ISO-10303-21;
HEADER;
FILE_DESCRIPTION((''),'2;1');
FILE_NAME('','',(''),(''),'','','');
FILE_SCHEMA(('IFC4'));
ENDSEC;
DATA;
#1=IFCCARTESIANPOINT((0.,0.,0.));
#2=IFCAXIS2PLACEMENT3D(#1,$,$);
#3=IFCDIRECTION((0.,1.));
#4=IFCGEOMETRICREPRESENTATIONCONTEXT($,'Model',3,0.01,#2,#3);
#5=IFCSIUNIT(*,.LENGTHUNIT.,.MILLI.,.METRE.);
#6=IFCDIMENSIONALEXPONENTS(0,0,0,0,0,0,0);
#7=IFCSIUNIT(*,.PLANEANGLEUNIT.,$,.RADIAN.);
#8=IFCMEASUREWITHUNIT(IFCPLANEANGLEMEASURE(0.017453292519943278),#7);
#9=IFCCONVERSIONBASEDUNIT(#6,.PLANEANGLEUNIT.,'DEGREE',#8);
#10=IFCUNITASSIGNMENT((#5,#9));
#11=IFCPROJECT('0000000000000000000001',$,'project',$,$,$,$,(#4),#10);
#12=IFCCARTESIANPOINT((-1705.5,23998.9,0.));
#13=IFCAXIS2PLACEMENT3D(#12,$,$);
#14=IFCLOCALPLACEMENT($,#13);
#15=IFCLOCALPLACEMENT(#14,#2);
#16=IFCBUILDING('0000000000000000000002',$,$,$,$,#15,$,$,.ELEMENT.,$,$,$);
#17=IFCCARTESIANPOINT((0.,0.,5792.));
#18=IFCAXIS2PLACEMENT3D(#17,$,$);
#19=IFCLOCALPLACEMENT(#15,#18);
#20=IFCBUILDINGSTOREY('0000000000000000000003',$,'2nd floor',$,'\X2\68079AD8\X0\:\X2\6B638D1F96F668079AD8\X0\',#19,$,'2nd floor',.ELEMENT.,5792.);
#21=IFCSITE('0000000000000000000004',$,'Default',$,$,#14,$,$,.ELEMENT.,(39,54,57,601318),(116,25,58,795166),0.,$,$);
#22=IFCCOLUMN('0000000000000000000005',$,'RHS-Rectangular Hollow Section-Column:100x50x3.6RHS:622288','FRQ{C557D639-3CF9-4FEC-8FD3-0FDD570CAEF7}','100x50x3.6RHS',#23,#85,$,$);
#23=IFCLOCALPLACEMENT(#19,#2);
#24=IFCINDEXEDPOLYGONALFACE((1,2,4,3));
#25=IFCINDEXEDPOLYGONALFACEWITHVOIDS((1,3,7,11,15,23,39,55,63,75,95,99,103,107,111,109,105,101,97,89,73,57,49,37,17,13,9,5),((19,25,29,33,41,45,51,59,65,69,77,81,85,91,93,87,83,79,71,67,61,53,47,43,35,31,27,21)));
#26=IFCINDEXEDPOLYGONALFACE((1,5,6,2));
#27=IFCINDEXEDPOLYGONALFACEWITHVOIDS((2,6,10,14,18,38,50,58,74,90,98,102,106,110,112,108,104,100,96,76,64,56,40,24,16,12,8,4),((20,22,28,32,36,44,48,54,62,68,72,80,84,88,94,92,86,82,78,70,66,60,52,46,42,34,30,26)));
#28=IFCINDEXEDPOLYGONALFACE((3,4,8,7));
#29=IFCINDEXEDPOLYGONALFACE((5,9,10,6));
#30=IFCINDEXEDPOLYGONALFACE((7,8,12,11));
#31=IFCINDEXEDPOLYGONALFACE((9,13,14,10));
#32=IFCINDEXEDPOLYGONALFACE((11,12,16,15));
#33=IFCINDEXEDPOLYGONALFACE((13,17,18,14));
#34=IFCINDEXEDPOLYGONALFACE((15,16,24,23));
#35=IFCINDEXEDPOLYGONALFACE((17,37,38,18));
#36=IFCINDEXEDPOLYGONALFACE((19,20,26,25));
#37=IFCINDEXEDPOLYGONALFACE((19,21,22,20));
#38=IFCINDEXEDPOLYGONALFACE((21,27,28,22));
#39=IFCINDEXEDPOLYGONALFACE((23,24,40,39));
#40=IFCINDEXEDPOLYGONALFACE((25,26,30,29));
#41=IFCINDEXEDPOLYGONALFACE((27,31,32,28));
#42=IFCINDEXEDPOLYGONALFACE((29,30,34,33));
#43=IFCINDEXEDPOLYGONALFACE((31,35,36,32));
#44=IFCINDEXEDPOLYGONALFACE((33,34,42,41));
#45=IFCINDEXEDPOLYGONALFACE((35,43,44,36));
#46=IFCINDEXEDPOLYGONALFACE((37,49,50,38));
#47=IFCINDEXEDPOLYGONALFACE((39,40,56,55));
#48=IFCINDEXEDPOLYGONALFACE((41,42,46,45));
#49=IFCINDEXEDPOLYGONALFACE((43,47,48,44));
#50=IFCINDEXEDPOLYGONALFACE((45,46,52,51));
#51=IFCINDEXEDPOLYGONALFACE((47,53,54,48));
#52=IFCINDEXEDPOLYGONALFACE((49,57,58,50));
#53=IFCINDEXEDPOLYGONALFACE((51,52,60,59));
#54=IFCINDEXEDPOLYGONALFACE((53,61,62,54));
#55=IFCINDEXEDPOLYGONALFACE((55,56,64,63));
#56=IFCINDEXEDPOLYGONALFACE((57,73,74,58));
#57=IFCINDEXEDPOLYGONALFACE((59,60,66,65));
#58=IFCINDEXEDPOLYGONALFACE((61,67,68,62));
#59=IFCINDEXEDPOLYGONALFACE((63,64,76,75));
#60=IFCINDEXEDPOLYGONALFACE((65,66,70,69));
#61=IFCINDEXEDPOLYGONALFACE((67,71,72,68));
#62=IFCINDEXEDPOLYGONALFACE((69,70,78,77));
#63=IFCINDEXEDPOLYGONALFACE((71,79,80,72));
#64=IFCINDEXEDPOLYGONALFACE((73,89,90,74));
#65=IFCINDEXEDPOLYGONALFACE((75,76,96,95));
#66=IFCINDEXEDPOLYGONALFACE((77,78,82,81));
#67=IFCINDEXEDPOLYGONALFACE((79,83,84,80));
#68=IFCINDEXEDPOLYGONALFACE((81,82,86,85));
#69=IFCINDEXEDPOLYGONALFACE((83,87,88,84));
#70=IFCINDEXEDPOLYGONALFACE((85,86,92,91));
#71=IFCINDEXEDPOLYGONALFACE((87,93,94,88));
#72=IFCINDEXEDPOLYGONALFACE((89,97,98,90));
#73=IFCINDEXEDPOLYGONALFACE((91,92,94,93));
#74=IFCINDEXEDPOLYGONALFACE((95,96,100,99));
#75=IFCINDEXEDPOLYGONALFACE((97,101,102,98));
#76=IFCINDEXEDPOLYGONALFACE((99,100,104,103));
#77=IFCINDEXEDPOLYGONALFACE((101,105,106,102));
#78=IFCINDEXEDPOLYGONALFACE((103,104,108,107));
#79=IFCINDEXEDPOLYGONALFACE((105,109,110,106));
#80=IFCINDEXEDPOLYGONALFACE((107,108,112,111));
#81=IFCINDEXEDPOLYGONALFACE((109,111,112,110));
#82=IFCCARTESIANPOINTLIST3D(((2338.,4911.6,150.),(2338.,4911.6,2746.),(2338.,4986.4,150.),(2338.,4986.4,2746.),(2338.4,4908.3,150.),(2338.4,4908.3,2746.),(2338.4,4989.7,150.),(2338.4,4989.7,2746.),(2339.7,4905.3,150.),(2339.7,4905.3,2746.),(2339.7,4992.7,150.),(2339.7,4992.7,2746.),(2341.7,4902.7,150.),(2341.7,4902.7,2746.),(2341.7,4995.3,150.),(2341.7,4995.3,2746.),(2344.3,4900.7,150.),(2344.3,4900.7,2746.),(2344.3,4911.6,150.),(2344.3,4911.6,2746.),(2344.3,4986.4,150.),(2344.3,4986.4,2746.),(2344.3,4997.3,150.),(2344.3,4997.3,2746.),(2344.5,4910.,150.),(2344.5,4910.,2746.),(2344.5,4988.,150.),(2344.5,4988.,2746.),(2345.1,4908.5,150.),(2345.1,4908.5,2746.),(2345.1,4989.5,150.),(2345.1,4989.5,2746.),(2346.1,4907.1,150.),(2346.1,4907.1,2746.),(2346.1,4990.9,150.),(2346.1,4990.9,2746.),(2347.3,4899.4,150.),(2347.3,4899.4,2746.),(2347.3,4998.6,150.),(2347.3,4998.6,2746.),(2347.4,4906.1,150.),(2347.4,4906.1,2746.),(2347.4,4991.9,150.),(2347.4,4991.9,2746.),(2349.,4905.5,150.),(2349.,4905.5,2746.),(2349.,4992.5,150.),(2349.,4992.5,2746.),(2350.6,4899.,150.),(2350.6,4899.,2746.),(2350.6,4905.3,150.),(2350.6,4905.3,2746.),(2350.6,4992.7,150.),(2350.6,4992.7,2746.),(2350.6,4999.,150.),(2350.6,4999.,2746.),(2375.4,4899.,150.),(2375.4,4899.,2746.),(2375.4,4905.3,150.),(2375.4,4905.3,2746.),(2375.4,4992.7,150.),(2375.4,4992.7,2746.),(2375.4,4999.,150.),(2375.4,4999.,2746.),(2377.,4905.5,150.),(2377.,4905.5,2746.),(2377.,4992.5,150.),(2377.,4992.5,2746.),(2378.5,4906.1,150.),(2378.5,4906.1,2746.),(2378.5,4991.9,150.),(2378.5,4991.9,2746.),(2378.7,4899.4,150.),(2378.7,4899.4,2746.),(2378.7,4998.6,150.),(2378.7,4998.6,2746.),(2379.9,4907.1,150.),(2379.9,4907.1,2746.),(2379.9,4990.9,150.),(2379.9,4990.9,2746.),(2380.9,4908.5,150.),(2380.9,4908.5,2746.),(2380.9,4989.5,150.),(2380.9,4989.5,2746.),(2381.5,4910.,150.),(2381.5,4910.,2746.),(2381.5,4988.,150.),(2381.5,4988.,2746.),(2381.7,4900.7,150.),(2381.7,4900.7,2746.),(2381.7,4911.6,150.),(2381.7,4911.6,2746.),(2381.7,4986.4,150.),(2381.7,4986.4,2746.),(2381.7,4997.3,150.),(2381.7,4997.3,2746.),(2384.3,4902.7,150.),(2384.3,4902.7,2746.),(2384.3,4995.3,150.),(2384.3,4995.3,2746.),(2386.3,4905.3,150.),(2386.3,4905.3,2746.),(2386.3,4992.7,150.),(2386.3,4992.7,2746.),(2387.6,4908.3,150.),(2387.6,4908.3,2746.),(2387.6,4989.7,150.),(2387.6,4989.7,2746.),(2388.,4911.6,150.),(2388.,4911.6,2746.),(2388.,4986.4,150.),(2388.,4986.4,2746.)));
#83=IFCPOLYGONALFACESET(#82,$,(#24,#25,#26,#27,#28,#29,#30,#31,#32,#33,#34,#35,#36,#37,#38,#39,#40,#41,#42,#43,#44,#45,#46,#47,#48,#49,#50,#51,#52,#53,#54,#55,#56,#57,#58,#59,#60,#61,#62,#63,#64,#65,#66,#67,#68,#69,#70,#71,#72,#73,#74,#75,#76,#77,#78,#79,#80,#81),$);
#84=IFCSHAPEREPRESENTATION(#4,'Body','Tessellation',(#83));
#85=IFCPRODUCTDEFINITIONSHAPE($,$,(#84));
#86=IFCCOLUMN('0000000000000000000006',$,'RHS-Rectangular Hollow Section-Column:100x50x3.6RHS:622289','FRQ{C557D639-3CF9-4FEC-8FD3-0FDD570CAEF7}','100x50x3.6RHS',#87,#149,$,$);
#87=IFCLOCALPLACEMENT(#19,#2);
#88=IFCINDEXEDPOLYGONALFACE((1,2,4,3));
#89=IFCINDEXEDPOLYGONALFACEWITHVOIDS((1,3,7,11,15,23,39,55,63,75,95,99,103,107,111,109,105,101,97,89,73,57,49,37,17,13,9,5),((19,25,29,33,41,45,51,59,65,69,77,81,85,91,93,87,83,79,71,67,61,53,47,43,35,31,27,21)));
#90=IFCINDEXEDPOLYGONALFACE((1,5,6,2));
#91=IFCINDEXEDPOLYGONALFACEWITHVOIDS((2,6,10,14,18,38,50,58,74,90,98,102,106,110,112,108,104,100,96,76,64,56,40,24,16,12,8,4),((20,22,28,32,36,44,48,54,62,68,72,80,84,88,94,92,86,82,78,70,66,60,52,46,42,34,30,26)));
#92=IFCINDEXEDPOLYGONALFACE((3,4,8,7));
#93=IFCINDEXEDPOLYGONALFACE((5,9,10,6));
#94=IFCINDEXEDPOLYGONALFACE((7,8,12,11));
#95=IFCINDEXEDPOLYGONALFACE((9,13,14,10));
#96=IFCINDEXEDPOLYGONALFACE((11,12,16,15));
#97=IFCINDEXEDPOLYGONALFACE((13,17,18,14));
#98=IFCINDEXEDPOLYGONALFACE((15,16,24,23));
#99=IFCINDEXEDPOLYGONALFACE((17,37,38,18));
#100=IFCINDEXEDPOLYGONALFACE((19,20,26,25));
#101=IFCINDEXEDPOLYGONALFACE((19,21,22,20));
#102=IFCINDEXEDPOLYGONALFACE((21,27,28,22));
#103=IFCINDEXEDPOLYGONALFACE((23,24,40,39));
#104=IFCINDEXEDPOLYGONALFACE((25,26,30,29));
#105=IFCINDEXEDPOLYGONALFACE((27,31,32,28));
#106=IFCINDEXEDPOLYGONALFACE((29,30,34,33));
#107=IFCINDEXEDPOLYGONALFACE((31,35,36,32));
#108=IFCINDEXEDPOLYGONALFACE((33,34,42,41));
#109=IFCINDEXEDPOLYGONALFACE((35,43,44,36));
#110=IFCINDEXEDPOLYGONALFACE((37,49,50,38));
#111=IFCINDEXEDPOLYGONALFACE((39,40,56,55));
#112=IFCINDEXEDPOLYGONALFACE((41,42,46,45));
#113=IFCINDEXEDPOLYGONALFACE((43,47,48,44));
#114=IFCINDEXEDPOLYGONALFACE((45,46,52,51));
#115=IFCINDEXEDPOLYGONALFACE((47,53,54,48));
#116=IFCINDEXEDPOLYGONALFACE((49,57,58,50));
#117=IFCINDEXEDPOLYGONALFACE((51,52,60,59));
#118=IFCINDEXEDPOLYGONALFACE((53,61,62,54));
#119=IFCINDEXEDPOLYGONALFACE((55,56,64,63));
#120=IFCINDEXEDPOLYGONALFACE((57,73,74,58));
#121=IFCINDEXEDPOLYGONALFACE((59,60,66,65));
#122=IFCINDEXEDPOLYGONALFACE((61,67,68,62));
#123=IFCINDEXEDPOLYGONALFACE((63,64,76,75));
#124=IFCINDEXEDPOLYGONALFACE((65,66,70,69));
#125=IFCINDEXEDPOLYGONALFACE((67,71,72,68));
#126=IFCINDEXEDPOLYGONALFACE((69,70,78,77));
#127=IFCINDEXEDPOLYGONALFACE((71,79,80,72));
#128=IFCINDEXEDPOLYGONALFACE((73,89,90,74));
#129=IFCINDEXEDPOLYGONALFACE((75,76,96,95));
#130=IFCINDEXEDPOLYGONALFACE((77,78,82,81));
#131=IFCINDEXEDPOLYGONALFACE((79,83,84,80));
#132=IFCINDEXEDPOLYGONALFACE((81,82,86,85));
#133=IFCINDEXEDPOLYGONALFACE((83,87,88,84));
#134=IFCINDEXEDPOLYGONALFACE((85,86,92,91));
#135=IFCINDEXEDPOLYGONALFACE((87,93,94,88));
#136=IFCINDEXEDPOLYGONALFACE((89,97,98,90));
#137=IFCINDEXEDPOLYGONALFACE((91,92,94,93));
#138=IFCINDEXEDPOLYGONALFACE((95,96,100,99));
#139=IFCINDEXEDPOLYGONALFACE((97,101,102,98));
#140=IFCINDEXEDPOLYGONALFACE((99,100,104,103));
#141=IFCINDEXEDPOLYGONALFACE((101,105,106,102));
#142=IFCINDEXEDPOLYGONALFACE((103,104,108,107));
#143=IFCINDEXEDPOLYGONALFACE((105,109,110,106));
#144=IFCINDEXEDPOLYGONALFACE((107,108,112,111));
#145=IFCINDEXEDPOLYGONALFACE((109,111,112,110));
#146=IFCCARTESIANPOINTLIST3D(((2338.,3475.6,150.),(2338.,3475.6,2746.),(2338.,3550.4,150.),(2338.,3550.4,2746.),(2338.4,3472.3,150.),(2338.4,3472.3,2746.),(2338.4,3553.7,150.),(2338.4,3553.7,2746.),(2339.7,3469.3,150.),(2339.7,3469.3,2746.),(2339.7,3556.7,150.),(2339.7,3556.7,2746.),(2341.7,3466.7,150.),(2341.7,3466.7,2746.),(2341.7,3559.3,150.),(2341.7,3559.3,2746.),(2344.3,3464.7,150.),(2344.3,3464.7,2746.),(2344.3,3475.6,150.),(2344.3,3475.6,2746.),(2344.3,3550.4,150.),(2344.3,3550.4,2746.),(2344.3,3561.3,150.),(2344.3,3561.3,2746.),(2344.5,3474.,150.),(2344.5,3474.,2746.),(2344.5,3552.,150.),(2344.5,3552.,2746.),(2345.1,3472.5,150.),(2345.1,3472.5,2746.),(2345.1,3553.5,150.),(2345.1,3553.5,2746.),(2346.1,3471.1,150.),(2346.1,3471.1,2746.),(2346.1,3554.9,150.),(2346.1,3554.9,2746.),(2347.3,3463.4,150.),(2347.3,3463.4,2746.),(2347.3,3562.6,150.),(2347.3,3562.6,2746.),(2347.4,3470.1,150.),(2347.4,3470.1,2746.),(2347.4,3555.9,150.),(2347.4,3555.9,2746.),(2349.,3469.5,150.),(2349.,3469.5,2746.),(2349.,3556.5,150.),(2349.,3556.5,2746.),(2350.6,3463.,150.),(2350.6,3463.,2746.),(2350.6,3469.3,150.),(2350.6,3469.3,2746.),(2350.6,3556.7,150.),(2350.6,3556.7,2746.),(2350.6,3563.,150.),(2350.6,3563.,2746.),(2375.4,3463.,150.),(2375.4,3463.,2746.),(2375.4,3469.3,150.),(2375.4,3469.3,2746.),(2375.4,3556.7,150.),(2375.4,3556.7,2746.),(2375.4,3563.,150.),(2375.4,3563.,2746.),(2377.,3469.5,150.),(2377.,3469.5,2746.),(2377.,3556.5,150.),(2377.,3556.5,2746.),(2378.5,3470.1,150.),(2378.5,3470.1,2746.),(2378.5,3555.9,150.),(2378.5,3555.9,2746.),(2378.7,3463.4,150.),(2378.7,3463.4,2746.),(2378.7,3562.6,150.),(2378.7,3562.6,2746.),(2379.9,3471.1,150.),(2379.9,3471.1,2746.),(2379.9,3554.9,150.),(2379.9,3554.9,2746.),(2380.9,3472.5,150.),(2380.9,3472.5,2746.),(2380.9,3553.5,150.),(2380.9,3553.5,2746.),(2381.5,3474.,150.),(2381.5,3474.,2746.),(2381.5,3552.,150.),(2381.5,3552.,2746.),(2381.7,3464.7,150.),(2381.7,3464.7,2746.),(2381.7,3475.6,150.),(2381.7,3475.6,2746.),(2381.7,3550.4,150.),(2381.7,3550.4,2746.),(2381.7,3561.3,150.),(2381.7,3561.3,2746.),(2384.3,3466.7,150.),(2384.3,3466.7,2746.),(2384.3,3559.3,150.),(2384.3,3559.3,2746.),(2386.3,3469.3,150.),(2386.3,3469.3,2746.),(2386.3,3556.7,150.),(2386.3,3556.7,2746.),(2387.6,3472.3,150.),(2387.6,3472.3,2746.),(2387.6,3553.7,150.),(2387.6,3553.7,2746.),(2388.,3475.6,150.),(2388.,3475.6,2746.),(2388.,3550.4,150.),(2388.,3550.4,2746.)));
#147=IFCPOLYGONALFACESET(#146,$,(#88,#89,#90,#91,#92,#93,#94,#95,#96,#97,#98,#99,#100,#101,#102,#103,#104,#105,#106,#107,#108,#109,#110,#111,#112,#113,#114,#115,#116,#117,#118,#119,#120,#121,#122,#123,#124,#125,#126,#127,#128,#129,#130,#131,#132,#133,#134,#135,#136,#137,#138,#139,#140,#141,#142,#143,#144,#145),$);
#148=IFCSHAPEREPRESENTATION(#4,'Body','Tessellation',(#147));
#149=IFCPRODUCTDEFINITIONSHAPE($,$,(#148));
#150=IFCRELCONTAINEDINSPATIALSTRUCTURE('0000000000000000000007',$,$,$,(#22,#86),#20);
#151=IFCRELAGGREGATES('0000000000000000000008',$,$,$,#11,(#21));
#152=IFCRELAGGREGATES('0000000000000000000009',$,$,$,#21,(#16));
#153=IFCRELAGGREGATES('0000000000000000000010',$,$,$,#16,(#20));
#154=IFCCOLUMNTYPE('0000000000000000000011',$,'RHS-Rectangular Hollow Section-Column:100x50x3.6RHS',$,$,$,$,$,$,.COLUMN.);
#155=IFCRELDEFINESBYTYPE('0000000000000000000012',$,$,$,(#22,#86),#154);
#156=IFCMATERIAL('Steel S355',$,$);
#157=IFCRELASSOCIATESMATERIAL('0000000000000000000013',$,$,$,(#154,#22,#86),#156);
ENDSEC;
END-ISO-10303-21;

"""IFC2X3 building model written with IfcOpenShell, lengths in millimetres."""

from ifc_helpers import new_model, entity, si_unit, converted_unit, direction, frame, origin, origin_2d, place, context, project, spatial, hollow_rectangle, extrude, clip, halfspace, material, type_object, element, save


model = new_model("IFC2X3")

# Units and contexts
model_context = context("Model", 3, precision=0.01, world=origin(), true_north=direction((0.0, 1.0)))
ifc_project = project(units=[si_unit("LENGTHUNIT", "METRE", prefix="MILLI"), converted_unit("PLANEANGLEUNIT", "DEGREE", entity("IfcPlaneAngleMeasure", 0.017453292519943278), si_unit("PLANEANGLEUNIT", "RADIAN"), dimensions=[0, 0, 0, 0, 0, 0, 0])], contexts=[model_context])

# Site, building, storey
site_placement = place(None, frame((-1705.5, 23998.9, 0.0)))
site = spatial("IfcSite", under=ifc_project, at=site_placement, Name="Default", CompositionType="ELEMENT", RefLatitude=(39, 54, 57, 601318), RefLongitude=(116, 25, 58, 795166), RefElevation=0.0)
building_placement = place(site_placement, origin())
building = spatial("IfcBuilding", under=site, at=building_placement, CompositionType="ELEMENT")
storey_placement = place(building_placement, frame((0.0, 0.0, 5792.0)))
storey = spatial("IfcBuildingStorey", under=building, at=storey_placement, Name="2nd floor", ObjectType="标高:正负零标高", LongName="2nd floor", CompositionType="ELEMENT", Elevation=5792.0)

# Columns
ifc_material_1 = material(Name="Steel S355")
column_type_1 = type_object("IfcColumnType", Name="RHS-Rectangular Hollow Section-Column:100x50x3.6RHS", PredefinedType="COLUMN", material=ifc_material_1)
column_1_placement = place(storey_placement, frame((2363.0, 4949.0, 2746.0), z_axis=(0.0, 0.0, 1.0), x_axis=(-1.0, 0.0, 0.0)))
element("IfcColumn", 1, at=column_1_placement, inside=storey, type_object=column_type_1, material=ifc_material_1, Name="RHS-Rectangular Hollow Section-Column:100x50x3.6RHS:622288", Description="FRQ{C557D639-3CF9-4FEC-8FD3-0FDD570CAEF7}", ObjectType="100x50x3.6RHS", context=model_context, shape_type="Clipping", body=[
    clip(extrude(hollow_rectangle(XDim=50.0, YDim=100.0, WallThickness=6.3, InnerFilletRadius=6.3, OuterFilletRadius=12.6, at=origin_2d()), origin(), (0.0, 0.0, -1.0), 2651.9), halfspace(frame((2363.0, 4949.0, -2596.0), z_axis=(0.0, 0.0, 1.0), x_axis=(-1.0, 0.0, 0.0)), True)),
])
column_2_placement = place(storey_placement, frame((2363.0, 3513.0, 2746.0), z_axis=(0.0, 0.0, 1.0), x_axis=(-1.0, 0.0, 0.0)))
element("IfcColumn", 2, at=column_2_placement, inside=storey, type_object=column_type_1, material=ifc_material_1, Name="RHS-Rectangular Hollow Section-Column:100x50x3.6RHS:622289", Description="FRQ{C557D639-3CF9-4FEC-8FD3-0FDD570CAEF7}", ObjectType="100x50x3.6RHS", context=model_context, shape_type="Clipping", body=[
    clip(extrude(hollow_rectangle(XDim=50.0, YDim=100.0, WallThickness=6.3, InnerFilletRadius=6.3, OuterFilletRadius=12.6, at=origin_2d()), origin(), (0.0, 0.0, -1.0), 2651.9), halfspace(frame((2363.0, 3513.0, -2596.0), z_axis=(0.0, 0.0, 1.0), x_axis=(-1.0, 0.0, 0.0)), True)),
])

save(model, "model.ifc")
